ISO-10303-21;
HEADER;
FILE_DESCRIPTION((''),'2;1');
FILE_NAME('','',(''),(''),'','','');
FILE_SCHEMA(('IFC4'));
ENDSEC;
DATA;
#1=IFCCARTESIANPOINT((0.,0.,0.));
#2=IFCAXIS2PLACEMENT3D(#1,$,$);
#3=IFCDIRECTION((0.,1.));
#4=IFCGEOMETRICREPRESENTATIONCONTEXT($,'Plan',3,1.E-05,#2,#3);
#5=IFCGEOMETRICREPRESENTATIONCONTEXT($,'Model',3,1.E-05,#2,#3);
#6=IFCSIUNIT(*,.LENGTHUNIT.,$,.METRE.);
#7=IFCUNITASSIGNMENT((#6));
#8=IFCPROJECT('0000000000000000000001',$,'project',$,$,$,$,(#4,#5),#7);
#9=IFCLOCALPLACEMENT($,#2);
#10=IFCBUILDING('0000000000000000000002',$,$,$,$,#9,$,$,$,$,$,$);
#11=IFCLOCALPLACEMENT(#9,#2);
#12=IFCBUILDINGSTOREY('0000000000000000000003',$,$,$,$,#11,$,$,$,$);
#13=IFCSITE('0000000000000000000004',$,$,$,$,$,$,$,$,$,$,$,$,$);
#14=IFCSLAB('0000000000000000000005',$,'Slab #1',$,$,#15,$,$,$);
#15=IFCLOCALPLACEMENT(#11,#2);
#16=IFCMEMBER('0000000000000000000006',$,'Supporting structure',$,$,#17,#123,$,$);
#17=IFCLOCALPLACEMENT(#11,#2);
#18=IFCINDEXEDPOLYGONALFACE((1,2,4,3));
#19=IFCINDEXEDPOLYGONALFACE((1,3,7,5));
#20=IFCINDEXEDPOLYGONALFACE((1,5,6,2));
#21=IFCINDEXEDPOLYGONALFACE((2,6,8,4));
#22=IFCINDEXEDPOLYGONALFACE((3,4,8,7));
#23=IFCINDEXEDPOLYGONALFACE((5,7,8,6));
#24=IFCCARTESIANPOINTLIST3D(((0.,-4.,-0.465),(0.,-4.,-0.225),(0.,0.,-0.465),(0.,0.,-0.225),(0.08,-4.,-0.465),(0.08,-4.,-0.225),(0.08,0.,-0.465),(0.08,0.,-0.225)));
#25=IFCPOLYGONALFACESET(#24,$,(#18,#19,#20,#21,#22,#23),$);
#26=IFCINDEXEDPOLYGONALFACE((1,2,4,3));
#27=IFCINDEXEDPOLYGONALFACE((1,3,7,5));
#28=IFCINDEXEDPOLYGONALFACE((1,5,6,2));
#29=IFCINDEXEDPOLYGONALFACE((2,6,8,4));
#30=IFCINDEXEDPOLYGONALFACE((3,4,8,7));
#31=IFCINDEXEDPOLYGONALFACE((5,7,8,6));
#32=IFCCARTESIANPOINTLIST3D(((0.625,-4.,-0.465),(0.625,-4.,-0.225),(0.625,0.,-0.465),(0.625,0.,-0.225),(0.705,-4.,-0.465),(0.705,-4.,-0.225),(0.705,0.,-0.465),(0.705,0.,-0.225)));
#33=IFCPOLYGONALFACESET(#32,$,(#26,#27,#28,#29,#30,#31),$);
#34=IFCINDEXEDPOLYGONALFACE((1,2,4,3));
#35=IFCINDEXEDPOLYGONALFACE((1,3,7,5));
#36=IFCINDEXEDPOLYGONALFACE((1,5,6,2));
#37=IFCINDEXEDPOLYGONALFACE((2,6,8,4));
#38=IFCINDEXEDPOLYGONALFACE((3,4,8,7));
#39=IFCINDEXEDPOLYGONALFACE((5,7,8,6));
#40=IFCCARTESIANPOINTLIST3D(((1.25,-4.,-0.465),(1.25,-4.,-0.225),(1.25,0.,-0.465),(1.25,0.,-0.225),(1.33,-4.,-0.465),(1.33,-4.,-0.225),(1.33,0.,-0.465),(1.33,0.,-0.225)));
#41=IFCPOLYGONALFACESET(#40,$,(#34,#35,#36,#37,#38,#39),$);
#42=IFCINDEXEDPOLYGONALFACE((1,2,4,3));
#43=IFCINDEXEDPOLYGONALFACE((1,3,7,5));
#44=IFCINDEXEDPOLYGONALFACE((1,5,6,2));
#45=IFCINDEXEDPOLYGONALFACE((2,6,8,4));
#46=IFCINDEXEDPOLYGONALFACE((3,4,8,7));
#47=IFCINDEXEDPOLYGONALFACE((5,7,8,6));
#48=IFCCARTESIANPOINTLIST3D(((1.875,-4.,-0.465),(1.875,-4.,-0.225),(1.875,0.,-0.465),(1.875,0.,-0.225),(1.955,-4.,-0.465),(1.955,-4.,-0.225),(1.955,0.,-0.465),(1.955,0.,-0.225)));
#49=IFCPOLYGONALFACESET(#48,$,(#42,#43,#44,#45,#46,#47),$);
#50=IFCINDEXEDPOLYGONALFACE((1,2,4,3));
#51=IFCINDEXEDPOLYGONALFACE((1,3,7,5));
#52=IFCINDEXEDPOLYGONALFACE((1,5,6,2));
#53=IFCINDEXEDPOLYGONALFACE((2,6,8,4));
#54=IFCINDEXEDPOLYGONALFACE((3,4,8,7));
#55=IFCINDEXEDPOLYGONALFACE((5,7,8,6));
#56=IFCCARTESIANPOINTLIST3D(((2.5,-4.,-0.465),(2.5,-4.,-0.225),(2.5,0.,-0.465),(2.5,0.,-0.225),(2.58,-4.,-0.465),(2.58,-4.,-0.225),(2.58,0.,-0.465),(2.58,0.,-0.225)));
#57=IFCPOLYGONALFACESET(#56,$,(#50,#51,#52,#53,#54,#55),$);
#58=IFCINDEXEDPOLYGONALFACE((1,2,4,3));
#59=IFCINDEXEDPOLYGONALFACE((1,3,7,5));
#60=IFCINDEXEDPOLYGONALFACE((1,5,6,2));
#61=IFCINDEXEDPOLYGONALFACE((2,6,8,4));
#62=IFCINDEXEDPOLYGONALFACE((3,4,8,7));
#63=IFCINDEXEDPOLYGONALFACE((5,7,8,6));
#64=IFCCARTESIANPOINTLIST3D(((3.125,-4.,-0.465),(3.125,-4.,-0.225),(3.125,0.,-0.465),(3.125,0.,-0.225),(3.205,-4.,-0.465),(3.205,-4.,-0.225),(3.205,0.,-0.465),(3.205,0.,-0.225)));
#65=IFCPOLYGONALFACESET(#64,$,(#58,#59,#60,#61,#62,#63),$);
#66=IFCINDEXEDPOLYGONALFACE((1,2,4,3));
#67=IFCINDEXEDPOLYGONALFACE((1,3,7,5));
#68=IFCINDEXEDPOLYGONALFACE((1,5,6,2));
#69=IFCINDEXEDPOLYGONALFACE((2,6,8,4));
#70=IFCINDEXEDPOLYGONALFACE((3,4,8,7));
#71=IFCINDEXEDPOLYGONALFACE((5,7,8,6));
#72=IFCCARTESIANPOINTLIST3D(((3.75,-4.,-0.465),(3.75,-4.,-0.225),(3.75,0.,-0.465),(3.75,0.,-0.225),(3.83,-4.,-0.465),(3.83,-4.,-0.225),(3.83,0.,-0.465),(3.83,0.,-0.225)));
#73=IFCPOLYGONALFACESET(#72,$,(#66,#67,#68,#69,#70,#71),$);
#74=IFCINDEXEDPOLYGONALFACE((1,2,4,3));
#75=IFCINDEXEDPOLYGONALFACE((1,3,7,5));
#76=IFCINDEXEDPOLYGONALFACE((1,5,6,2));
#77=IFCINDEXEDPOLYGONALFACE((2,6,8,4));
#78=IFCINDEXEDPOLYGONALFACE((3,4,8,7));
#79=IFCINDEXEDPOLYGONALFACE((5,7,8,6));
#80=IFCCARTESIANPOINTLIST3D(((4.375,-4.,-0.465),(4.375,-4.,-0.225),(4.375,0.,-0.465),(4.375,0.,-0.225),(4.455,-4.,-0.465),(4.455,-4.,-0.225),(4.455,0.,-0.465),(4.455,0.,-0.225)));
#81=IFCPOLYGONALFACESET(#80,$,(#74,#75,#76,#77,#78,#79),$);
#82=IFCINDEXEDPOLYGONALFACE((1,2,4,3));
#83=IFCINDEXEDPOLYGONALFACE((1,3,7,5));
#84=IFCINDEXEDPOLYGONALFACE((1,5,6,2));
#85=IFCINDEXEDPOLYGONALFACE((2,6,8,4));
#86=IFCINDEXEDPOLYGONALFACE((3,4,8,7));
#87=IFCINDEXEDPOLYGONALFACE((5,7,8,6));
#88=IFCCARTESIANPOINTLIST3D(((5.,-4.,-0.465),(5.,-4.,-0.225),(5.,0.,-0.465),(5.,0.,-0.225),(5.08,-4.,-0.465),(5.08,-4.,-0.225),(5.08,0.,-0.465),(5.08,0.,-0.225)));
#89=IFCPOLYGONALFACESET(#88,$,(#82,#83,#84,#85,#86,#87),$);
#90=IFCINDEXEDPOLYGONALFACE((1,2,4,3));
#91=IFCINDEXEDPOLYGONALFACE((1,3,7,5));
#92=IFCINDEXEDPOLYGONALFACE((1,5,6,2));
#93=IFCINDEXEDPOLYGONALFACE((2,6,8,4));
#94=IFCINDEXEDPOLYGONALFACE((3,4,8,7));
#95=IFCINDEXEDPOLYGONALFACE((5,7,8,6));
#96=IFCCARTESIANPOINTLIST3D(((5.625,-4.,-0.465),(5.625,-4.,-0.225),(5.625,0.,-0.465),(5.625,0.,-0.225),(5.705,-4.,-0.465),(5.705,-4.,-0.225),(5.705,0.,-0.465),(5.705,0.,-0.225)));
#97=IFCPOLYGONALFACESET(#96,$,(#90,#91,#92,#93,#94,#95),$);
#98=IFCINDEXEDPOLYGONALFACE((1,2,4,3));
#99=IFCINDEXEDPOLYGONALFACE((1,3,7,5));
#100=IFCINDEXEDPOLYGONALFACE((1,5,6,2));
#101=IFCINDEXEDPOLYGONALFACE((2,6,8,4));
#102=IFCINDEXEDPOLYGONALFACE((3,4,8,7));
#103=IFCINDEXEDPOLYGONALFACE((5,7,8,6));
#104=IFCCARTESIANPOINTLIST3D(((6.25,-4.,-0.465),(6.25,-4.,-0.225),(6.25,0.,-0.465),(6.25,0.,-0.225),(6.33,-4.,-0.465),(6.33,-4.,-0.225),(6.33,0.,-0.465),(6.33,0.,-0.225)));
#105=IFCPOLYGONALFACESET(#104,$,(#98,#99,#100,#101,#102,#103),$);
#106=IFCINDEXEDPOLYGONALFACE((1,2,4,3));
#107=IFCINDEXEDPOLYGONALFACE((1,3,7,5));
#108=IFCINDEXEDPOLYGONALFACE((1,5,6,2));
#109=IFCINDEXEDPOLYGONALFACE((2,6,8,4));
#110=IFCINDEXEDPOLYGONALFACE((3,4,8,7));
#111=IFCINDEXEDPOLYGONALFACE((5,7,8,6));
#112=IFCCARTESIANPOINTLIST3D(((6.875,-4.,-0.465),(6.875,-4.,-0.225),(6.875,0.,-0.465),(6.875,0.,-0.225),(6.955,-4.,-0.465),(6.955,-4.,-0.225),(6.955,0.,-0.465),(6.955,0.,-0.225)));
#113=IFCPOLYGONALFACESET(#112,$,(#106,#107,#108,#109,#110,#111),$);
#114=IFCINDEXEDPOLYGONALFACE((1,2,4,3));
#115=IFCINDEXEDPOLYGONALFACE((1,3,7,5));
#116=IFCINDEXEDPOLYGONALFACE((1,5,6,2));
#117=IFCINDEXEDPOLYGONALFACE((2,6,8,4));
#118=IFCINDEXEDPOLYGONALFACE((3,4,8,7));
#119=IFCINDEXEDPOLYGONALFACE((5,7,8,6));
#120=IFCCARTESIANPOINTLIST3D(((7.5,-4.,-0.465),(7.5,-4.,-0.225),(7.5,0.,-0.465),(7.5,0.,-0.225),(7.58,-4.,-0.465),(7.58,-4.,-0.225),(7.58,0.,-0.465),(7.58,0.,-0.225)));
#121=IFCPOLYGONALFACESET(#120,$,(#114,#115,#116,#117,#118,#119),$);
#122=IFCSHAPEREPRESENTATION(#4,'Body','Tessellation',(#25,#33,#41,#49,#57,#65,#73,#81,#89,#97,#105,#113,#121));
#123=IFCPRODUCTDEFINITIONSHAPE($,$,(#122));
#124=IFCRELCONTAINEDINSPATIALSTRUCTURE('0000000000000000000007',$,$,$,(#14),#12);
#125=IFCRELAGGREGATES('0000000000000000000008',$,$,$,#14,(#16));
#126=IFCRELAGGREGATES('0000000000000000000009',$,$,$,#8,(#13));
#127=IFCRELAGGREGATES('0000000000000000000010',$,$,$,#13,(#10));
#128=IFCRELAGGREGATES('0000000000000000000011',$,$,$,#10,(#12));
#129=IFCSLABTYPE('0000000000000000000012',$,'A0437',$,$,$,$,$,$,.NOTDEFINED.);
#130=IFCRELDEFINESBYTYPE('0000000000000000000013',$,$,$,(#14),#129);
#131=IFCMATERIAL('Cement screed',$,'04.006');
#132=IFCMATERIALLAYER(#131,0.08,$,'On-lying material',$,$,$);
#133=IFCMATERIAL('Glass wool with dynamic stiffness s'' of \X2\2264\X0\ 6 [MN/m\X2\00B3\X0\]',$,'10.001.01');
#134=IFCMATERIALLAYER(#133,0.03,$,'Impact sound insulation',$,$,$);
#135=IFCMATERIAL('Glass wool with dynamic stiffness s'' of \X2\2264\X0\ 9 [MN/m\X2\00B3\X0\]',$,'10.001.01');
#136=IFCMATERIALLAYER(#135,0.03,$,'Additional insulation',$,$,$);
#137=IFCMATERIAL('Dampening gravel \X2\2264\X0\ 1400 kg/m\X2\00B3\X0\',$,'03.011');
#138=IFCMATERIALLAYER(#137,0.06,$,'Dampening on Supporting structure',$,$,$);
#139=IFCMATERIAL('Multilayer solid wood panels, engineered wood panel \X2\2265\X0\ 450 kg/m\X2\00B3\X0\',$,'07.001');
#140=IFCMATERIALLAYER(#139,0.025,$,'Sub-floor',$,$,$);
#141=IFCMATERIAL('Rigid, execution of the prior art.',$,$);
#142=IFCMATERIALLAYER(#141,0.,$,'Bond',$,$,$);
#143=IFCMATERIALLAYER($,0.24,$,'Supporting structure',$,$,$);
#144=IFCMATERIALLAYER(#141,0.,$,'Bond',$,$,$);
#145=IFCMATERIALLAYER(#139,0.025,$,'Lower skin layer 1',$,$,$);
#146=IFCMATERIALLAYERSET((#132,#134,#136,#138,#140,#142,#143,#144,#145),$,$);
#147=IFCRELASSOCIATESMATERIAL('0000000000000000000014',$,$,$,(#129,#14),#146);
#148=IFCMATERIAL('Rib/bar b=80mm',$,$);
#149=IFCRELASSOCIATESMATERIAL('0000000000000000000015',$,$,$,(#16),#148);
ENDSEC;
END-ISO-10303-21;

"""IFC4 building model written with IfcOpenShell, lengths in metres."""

from ifc_helpers import new_model, si_unit, direction, frame, frame_2d, origin, place, context, project, spatial, rectangle, extrude, material, layer, layer_set, type_object, element, aggregate, save


model = new_model("IFC4")

# Units and contexts
plan_context = context("Plan", 3, precision=1e-05, world=origin(), true_north=direction((0.0, 1.0)))
model_context = context("Model", 3, precision=1e-05, world=origin(), true_north=direction((0.0, 1.0)))
ifc_project = project(units=[si_unit("LENGTHUNIT", "METRE")], contexts=[plan_context, model_context])

# Site, building, storey
site = spatial("IfcSite", under=ifc_project)
building_placement = place(None, origin())
building = spatial("IfcBuilding", under=site, at=building_placement)
storey_placement = place(building_placement, origin())
storey = spatial("IfcBuildingStorey", under=building, at=storey_placement)

# Slab, member
ifc_material_1 = material(Name="Cement screed", Category="04.006")
ifc_layer_1 = layer(ifc_material_1, 0.08, Name="On-lying material")
ifc_material_2 = material(Name="Glass wool with dynamic stiffness s' of ≤ 6 [MN/m³]", Category="10.001.01")
ifc_layer_2 = layer(ifc_material_2, 0.03, Name="Impact sound insulation")
ifc_material_3 = material(Name="Glass wool with dynamic stiffness s' of ≤ 9 [MN/m³]", Category="10.001.01")
ifc_layer_3 = layer(ifc_material_3, 0.03, Name="Additional insulation")
ifc_material_4 = material(Name="Dampening gravel ≤ 1400 kg/m³", Category="03.011")
ifc_layer_4 = layer(ifc_material_4, 0.06, Name="Dampening on Supporting structure")
ifc_material_5 = material(Name="Multilayer solid wood panels, engineered wood panel ≥ 450 kg/m³", Category="07.001")
ifc_layer_5 = layer(ifc_material_5, 0.025, Name="Sub-floor")
ifc_material_6 = material(Name="Rigid, execution of the prior art.")
ifc_layer_6 = layer(ifc_material_6, 0.0, Name="Bond")
ifc_layer_7 = layer(None, 0.24, Name="Supporting structure")
ifc_layer_8 = layer(ifc_material_6, 0.0, Name="Bond")
ifc_layer_9 = layer(ifc_material_5, 0.025, Name="Lower skin layer 1")
ifc_layer_set = layer_set([ifc_layer_1, ifc_layer_2, ifc_layer_3, ifc_layer_4, ifc_layer_5, ifc_layer_6, ifc_layer_7, ifc_layer_8, ifc_layer_9])
slab_type = type_object("IfcSlabType", Name="A0437", PredefinedType="NOTDEFINED", material=ifc_layer_set)
slab_placement = place(None, frame((0.0, 0.0, 0.0), z_axis=(0.0, 0.0, -1.0), x_axis=(1.0, 0.0, 0.0)))
slab = element("IfcSlab", 1, at=slab_placement, inside=storey, type_object=slab_type, material=ifc_layer_set, Name="Slab #1")
ifc_material_7 = material(Name="Rib/bar b=80mm")
member_1_placement = place(slab_placement, origin())
member_1 = element("IfcMember", 2, at=member_1_placement, material=ifc_material_7, Name="Supporting structure", context=plan_context, shape_type="SweptSolid", body=[
    extrude(rectangle(XDim=0.08, YDim=0.24, at=frame_2d((0.04, 0.12), x_axis=(1.0, 0.0))), frame((0.0, 4.0, 0.225), z_axis=(0.0, -1.0, 0.0), x_axis=(1.0, 0.0, 0.0)), (0.0, 0.0, 1.0), 4.0),
    extrude(rectangle(XDim=0.08, YDim=0.24, at=frame_2d((0.04, 0.12), x_axis=(1.0, 0.0))), frame((0.625, 4.0, 0.225), z_axis=(0.0, -1.0, 0.0), x_axis=(1.0, 0.0, 0.0)), (0.0, 0.0, 1.0), 4.0),
    extrude(rectangle(XDim=0.08, YDim=0.24, at=frame_2d((0.04, 0.12), x_axis=(1.0, 0.0))), frame((1.25, 4.0, 0.225), z_axis=(0.0, -1.0, 0.0), x_axis=(1.0, 0.0, 0.0)), (0.0, 0.0, 1.0), 4.0),
    extrude(rectangle(XDim=0.08, YDim=0.24, at=frame_2d((0.04, 0.12), x_axis=(1.0, 0.0))), frame((1.875, 4.0, 0.225), z_axis=(0.0, -1.0, 0.0), x_axis=(1.0, 0.0, 0.0)), (0.0, 0.0, 1.0), 4.0),
    extrude(rectangle(XDim=0.08, YDim=0.24, at=frame_2d((0.04, 0.12), x_axis=(1.0, 0.0))), frame((2.5, 4.0, 0.225), z_axis=(0.0, -1.0, 0.0), x_axis=(1.0, 0.0, 0.0)), (0.0, 0.0, 1.0), 4.0),
    extrude(rectangle(XDim=0.08, YDim=0.24, at=frame_2d((0.04, 0.12), x_axis=(1.0, 0.0))), frame((3.125, 4.0, 0.225), z_axis=(0.0, -1.0, 0.0), x_axis=(1.0, 0.0, 0.0)), (0.0, 0.0, 1.0), 4.0),
    extrude(rectangle(XDim=0.08, YDim=0.24, at=frame_2d((0.04, 0.12), x_axis=(1.0, 0.0))), frame((3.75, 4.0, 0.225), z_axis=(0.0, -1.0, 0.0), x_axis=(1.0, 0.0, 0.0)), (0.0, 0.0, 1.0), 4.0),
    extrude(rectangle(XDim=0.08, YDim=0.24, at=frame_2d((0.04, 0.12), x_axis=(1.0, 0.0))), frame((4.375, 4.0, 0.225), z_axis=(0.0, -1.0, 0.0), x_axis=(1.0, 0.0, 0.0)), (0.0, 0.0, 1.0), 4.0),
    extrude(rectangle(XDim=0.08, YDim=0.24, at=frame_2d((0.04, 0.12), x_axis=(1.0, 0.0))), frame((5.0, 4.0, 0.225), z_axis=(0.0, -1.0, 0.0), x_axis=(1.0, 0.0, 0.0)), (0.0, 0.0, 1.0), 4.0),
    extrude(rectangle(XDim=0.08, YDim=0.24, at=frame_2d((0.04, 0.12), x_axis=(1.0, 0.0))), frame((5.625, 4.0, 0.225), z_axis=(0.0, -1.0, 0.0), x_axis=(1.0, 0.0, 0.0)), (0.0, 0.0, 1.0), 4.0),
    extrude(rectangle(XDim=0.08, YDim=0.24, at=frame_2d((0.04, 0.12), x_axis=(1.0, 0.0))), frame((6.25, 4.0, 0.225), z_axis=(0.0, -1.0, 0.0), x_axis=(1.0, 0.0, 0.0)), (0.0, 0.0, 1.0), 4.0),
    extrude(rectangle(XDim=0.08, YDim=0.24, at=frame_2d((0.04, 0.12), x_axis=(1.0, 0.0))), frame((6.875, 4.0, 0.225), z_axis=(0.0, -1.0, 0.0), x_axis=(1.0, 0.0, 0.0)), (0.0, 0.0, 1.0), 4.0),
    extrude(rectangle(XDim=0.08, YDim=0.24, at=frame_2d((0.04, 0.12), x_axis=(1.0, 0.0))), frame((7.5, 4.0, 0.225), z_axis=(0.0, -1.0, 0.0), x_axis=(1.0, 0.0, 0.0)), (0.0, 0.0, 1.0), 4.0),
])
aggregate(slab, [member_1])

save(model, "model.ifc")
